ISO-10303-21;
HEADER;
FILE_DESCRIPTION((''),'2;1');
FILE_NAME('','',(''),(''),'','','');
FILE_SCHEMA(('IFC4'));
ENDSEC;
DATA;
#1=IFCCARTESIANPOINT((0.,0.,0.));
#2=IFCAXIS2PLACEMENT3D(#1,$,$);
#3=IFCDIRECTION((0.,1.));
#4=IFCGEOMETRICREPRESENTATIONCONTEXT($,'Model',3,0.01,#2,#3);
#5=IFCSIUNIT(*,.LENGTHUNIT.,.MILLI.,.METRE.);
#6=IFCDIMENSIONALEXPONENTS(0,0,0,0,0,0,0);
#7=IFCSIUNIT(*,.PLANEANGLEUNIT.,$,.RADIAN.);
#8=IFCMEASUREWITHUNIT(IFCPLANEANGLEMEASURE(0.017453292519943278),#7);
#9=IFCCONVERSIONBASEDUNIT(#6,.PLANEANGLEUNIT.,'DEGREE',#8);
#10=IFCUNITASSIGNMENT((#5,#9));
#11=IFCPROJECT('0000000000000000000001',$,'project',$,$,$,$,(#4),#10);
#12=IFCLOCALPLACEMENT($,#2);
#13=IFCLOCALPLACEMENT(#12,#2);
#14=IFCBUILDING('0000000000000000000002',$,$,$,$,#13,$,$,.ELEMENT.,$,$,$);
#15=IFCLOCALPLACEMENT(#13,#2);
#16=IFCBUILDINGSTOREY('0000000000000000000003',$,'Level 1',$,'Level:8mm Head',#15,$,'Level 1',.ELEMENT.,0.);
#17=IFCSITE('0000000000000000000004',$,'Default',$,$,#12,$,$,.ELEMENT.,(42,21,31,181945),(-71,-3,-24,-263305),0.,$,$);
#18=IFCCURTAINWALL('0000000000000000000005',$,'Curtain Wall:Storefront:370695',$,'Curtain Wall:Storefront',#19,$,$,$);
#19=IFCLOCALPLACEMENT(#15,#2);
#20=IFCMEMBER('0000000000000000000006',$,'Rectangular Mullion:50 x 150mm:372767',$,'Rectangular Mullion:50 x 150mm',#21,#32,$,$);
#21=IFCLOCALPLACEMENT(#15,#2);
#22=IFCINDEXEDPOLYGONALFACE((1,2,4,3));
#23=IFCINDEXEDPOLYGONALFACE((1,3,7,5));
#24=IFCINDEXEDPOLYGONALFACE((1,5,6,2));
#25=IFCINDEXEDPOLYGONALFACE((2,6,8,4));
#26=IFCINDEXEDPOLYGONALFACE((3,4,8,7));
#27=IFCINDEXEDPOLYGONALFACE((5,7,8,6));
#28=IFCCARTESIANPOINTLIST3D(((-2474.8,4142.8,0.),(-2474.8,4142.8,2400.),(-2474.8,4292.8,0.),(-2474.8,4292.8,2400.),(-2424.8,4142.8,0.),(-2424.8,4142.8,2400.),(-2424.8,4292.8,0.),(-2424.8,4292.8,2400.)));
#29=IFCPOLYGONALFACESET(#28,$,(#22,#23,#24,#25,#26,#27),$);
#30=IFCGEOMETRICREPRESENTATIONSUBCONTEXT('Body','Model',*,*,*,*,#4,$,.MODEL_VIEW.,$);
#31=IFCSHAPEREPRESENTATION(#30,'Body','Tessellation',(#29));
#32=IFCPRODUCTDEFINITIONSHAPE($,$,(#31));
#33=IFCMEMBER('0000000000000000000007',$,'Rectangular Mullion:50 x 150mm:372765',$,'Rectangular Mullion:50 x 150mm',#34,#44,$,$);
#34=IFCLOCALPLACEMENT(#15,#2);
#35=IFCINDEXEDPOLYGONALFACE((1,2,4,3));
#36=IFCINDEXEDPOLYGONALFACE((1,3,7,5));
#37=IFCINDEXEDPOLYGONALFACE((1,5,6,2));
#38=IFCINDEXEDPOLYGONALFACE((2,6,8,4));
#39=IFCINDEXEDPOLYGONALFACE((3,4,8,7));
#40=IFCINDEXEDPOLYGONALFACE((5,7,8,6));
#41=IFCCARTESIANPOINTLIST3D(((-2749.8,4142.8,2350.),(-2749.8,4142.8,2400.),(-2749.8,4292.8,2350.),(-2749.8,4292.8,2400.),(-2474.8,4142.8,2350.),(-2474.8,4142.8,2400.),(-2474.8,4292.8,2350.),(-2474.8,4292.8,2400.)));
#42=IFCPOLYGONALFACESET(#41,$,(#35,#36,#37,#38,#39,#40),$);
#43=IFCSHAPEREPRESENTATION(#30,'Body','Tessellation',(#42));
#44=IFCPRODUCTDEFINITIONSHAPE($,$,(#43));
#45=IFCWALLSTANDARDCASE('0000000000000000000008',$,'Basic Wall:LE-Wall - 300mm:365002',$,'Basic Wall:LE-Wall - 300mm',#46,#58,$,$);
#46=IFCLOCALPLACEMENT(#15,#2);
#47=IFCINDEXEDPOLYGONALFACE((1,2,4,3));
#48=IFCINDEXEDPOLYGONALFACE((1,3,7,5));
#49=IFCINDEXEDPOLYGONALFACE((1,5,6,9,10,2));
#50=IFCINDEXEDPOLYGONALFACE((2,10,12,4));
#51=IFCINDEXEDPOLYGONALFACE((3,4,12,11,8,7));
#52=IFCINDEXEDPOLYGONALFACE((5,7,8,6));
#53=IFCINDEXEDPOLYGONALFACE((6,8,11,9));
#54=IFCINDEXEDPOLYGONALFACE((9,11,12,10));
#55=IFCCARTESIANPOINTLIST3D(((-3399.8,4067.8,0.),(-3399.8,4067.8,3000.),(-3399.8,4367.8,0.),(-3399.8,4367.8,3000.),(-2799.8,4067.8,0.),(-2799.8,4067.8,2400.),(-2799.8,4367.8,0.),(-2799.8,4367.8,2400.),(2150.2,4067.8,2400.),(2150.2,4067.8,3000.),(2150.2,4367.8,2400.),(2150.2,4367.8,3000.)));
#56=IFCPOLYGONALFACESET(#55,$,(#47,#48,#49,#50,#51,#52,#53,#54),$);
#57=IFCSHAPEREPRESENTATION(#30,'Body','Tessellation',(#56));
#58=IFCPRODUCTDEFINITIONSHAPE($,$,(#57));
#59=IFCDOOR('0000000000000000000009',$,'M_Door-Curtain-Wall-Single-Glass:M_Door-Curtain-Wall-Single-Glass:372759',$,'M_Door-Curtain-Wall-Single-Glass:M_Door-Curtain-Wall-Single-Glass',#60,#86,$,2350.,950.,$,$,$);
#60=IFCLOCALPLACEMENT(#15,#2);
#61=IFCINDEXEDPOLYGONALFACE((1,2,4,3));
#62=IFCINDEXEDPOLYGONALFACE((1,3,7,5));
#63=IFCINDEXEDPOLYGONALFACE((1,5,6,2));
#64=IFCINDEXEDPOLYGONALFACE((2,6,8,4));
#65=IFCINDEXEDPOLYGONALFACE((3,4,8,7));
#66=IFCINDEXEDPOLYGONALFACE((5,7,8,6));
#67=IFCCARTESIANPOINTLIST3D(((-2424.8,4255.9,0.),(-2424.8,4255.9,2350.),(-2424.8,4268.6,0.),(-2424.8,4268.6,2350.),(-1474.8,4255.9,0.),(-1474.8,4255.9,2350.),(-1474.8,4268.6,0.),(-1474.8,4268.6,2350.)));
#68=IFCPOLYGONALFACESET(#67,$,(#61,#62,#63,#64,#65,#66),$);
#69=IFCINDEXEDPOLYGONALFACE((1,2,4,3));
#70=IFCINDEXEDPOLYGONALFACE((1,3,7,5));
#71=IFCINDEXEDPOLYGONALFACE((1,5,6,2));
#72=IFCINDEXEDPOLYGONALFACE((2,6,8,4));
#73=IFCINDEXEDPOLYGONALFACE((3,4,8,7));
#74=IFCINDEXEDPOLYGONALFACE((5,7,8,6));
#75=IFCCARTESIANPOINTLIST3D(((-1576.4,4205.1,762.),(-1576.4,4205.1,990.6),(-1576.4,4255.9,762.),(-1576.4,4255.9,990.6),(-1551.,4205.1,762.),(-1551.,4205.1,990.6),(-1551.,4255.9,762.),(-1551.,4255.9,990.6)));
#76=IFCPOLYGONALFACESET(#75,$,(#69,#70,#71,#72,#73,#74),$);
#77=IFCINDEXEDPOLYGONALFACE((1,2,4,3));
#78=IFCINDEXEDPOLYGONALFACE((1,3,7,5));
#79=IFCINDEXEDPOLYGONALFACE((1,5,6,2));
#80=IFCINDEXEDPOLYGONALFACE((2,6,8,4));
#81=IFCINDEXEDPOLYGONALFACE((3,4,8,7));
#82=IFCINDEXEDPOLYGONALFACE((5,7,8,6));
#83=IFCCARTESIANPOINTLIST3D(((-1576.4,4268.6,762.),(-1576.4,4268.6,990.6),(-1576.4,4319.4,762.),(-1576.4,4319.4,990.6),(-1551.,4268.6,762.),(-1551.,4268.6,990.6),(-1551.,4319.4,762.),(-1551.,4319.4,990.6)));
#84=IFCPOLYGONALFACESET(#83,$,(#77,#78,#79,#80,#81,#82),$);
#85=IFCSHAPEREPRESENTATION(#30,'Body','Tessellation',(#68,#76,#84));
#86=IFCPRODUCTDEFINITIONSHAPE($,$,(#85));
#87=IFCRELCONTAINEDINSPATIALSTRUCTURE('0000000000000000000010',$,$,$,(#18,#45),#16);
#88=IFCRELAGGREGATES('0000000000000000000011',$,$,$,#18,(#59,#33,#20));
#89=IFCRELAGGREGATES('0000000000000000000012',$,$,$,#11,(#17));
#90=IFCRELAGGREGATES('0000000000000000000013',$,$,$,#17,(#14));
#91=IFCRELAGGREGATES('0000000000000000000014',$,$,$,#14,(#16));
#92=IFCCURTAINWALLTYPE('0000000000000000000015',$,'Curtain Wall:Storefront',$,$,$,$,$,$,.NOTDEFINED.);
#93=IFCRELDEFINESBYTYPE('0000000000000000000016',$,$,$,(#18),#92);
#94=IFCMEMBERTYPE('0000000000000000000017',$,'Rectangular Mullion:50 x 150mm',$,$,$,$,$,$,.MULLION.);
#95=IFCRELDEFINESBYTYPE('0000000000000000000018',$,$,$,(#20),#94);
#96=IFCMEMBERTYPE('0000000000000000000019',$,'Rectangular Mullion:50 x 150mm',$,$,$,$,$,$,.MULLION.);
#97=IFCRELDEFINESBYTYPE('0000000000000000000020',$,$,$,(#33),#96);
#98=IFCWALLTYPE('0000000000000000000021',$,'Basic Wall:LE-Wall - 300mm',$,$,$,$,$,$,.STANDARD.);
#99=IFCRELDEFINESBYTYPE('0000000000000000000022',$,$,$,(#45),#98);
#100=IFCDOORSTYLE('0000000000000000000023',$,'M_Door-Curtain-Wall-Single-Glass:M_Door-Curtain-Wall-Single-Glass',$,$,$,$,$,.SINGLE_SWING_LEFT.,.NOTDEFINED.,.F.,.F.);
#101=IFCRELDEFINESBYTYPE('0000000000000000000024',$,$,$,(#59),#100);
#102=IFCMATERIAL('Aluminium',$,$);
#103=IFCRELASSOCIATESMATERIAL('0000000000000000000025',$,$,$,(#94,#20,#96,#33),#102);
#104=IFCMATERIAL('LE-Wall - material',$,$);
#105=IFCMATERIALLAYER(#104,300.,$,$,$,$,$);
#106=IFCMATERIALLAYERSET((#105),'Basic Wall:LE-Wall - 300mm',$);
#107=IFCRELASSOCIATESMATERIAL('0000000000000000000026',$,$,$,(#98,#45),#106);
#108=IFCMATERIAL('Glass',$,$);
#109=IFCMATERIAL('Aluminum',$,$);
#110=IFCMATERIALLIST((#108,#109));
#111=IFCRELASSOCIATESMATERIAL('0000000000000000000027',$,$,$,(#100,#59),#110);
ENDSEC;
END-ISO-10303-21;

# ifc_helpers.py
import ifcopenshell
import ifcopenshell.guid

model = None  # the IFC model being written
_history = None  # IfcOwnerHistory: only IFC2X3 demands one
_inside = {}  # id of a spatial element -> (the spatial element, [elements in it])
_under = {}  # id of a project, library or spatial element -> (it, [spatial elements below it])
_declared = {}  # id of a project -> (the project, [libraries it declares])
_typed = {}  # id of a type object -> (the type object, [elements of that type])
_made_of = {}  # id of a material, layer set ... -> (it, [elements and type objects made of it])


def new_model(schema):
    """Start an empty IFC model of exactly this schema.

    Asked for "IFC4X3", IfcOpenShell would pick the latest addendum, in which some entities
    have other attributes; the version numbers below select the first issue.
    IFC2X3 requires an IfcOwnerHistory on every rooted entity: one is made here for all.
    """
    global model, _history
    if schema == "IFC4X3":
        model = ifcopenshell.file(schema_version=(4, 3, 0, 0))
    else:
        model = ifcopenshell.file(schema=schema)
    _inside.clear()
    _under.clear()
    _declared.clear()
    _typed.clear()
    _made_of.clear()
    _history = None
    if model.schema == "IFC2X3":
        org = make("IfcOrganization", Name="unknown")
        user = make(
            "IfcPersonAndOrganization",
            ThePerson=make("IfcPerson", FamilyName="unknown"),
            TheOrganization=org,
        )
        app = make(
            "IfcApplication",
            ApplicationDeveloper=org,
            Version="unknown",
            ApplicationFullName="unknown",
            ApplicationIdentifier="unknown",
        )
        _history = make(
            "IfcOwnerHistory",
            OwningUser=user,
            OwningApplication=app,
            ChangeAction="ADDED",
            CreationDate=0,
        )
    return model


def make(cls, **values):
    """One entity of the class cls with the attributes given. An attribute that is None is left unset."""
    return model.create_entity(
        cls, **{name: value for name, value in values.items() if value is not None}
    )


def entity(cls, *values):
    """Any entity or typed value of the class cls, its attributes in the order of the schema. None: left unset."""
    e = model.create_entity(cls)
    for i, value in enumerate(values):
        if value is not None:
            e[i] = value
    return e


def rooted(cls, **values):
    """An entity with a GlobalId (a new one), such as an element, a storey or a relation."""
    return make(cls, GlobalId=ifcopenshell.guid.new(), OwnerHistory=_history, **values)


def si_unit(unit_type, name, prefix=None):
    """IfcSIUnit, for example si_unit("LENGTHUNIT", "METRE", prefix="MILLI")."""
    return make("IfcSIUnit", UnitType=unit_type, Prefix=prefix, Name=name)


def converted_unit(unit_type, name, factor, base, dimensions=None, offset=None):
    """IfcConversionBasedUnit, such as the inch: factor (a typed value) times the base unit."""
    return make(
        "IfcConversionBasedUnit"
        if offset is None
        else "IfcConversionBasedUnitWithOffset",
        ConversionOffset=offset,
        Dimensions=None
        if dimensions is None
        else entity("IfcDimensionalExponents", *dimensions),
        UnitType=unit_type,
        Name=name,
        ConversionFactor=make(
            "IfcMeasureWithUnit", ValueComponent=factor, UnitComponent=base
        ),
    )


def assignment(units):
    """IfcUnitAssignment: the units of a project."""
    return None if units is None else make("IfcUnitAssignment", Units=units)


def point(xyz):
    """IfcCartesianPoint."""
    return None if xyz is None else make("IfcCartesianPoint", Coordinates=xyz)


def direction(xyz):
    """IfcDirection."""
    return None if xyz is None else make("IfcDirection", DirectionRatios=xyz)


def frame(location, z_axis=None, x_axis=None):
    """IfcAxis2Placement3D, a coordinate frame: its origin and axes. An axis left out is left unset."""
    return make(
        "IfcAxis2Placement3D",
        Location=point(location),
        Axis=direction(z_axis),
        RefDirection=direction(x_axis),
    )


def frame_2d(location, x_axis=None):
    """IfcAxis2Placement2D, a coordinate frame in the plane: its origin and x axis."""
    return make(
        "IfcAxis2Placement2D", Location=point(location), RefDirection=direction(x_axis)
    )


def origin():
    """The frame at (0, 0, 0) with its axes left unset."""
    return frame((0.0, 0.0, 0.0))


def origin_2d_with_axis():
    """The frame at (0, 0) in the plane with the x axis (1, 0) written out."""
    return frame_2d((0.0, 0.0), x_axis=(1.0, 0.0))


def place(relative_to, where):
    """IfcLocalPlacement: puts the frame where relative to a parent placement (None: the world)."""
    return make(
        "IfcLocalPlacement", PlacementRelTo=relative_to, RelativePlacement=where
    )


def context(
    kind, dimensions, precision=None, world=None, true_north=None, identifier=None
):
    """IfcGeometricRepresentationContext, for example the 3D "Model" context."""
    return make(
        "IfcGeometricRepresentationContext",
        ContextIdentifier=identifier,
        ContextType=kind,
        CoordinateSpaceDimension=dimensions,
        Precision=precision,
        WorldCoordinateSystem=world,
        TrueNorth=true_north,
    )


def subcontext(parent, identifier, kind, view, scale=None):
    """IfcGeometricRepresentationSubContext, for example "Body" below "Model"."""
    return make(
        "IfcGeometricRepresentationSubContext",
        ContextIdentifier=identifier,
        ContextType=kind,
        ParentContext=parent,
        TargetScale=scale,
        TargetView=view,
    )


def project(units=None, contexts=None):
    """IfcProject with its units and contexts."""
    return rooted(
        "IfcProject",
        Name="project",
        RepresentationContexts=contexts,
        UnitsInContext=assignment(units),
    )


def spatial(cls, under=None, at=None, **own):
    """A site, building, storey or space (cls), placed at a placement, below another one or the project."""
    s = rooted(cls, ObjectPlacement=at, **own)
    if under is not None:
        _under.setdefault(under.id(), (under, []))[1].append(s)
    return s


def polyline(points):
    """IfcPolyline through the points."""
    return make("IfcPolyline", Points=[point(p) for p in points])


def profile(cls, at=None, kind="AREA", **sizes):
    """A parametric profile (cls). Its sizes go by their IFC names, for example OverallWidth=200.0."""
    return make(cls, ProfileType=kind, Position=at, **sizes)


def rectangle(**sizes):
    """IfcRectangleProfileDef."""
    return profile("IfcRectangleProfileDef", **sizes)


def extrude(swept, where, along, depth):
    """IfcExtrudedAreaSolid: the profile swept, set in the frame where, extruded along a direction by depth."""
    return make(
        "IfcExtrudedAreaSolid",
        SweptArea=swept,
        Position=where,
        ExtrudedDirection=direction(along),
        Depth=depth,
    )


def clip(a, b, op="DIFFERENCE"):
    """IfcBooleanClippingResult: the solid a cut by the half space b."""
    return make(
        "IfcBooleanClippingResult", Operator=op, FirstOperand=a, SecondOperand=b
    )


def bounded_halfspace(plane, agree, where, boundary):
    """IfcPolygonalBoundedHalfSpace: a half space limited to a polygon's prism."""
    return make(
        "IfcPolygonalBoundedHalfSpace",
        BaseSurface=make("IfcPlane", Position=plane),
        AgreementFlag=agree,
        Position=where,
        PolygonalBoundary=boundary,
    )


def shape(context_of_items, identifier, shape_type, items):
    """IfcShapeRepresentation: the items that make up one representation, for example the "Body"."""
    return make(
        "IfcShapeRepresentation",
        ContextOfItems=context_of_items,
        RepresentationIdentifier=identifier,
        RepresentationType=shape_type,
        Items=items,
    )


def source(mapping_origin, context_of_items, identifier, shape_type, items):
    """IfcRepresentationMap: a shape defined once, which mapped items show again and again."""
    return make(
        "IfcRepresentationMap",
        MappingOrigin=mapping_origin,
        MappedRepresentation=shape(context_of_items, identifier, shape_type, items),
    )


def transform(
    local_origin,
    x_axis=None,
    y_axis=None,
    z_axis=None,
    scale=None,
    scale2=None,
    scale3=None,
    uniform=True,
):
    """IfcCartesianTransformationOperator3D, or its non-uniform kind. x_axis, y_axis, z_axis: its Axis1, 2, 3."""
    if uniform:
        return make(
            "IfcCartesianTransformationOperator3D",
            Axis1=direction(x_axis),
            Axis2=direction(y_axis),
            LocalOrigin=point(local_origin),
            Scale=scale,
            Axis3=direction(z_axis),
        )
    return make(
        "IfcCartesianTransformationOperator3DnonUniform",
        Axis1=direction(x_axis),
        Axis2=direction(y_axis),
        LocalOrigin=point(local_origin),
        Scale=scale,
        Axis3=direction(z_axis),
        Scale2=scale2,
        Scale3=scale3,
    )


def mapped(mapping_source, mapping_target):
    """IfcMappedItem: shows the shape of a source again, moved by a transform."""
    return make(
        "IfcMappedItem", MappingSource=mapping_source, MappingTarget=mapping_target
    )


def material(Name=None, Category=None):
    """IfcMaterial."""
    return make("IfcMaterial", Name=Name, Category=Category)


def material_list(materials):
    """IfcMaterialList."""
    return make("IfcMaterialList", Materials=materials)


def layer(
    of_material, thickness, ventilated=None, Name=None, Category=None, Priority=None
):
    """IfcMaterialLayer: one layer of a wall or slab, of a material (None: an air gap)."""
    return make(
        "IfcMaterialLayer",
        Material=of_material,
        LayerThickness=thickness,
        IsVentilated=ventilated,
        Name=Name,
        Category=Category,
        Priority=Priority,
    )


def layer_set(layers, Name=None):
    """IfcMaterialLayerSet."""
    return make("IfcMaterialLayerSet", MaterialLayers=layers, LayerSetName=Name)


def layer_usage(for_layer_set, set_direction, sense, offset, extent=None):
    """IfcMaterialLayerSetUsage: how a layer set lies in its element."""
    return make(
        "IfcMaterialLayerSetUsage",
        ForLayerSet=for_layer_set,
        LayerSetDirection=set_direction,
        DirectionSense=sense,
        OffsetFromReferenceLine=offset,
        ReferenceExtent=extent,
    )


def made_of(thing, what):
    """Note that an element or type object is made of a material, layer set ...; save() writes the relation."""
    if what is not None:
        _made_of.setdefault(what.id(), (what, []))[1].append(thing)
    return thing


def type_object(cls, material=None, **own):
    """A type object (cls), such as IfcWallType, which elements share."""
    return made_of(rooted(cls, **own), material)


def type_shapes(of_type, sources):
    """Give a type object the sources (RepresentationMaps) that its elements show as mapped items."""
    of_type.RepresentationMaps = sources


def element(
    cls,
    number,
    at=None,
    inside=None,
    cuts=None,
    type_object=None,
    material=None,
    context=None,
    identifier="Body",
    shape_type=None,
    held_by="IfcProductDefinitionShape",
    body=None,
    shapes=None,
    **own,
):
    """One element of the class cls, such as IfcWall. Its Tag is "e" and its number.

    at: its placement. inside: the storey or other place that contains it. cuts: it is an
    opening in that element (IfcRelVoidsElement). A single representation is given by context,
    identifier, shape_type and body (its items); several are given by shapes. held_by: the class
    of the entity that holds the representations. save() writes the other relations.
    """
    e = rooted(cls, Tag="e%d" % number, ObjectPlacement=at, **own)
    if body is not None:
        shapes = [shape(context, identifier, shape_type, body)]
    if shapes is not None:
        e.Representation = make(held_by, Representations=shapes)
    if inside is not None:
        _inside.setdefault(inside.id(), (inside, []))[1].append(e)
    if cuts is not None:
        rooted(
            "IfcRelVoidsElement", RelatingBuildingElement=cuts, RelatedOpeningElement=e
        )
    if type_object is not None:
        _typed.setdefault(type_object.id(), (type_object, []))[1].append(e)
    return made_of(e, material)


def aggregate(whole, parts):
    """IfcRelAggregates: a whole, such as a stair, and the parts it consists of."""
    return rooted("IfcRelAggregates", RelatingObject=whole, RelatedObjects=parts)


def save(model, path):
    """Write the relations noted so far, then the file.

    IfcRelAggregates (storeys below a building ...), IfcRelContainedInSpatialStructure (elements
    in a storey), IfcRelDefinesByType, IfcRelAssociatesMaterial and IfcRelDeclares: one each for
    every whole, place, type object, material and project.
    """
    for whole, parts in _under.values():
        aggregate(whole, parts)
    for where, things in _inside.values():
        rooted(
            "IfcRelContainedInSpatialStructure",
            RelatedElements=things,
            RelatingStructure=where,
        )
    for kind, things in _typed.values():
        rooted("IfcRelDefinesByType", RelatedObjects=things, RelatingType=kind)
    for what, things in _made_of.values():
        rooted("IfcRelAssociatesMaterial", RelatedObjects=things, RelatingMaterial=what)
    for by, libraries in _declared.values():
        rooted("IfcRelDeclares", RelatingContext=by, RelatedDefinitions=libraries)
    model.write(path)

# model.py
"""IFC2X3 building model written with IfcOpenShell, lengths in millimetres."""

from ifc_helpers import new_model, entity, si_unit, converted_unit, direction, frame, frame_2d, origin, origin_2d_with_axis, place, context, subcontext, project, spatial, polyline, rectangle, extrude, clip, bounded_halfspace, source, transform, mapped, material, material_list, layer, layer_set, layer_usage, type_object, type_shapes, element, aggregate, save


model = new_model("IFC2X3")

# Units and contexts
model_context = context("Model", 3, precision=0.01, world=origin(), true_north=direction((0.0, 1.0)))
body_context = subcontext(model_context, "Body", "Model", "MODEL_VIEW")
ifc_project = project(units=[si_unit("LENGTHUNIT", "METRE", prefix="MILLI"), converted_unit("PLANEANGLEUNIT", "DEGREE", entity("IfcPlaneAngleMeasure", 0.017453292519943278), si_unit("PLANEANGLEUNIT", "RADIAN"), dimensions=[0, 0, 0, 0, 0, 0, 0])], contexts=[model_context])

# Site, building, storey
site_placement = place(None, origin())
site = spatial("IfcSite", under=ifc_project, at=site_placement, Name="Default", CompositionType="ELEMENT", RefLatitude=(42, 21, 31, 181945), RefLongitude=(-71, -3, -24, -263305), RefElevation=0.0)
building_placement = place(site_placement, origin())
building = spatial("IfcBuilding", under=site, at=building_placement, CompositionType="ELEMENT")
storey_placement = place(building_placement, origin())
storey = spatial("IfcBuildingStorey", under=building, at=storey_placement, Name="Level 1", ObjectType="Level:8mm Head", LongName="Level 1", CompositionType="ELEMENT", Elevation=0.0)

# Curtain wall, members
curtain_wall_type = type_object("IfcCurtainWallType", Name="Curtain Wall:Storefront", PredefinedType="NOTDEFINED")
curtain_wall_placement = place(storey_placement, origin())
curtain_wall = element("IfcCurtainWall", 1, at=curtain_wall_placement, inside=storey, type_object=curtain_wall_type, Name="Curtain Wall:Storefront:370695", ObjectType="Curtain Wall:Storefront")
ifc_material_1 = material(Name="Aluminium")
member_type_1 = type_object("IfcMemberType", Name="Rectangular Mullion:50 x 150mm", PredefinedType="MULLION", material=ifc_material_1)
shared_shape_1 = source(origin(), body_context, "Body", "SweptSolid", [
    extrude(rectangle(XDim=50.0, YDim=150.0, at=origin_2d_with_axis()), frame((0.0, 0.0, -2400.0), z_axis=(0.0, 0.0, 1.0), x_axis=(-1.0, 0.0, 0.0)), (0.0, 0.0, 1.0), 2400.0),
])
type_shapes(member_type_1, [shared_shape_1])
member_1_placement = place(curtain_wall_placement, frame((-2449.8, 4217.8, 0.0), z_axis=(0.0, 0.0, -1.0), x_axis=(1.0, 0.0, 0.0)))
member_1 = element("IfcMember", 2, at=member_1_placement, type_object=member_type_1, material=ifc_material_1, Name="Rectangular Mullion:50 x 150mm:372767", ObjectType="Rectangular Mullion:50 x 150mm", context=body_context, shape_type="MappedRepresentation", body=[
    mapped(shared_shape_1, transform((0.0, 0.0, 0.0), scale=1.0)),
])
member_type_2 = type_object("IfcMemberType", Name="Rectangular Mullion:50 x 150mm", PredefinedType="MULLION", material=ifc_material_1)
shared_shape_2 = source(origin(), body_context, "Body", "SweptSolid", [
    extrude(rectangle(XDim=50.0, YDim=150.0, at=origin_2d_with_axis()), frame((-25.0, 0.0, -275.0), z_axis=(0.0, 0.0, 1.0), x_axis=(-1.0, 0.0, 0.0)), (0.0, 0.0, 1.0), 275.0),
])
type_shapes(member_type_2, [shared_shape_2])
member_2_placement = place(curtain_wall_placement, frame((-2474.8, 4217.8, 2400.0), z_axis=(1.0, 0.0, 0.0), x_axis=(0.0, 0.0, 1.0)))
member_2 = element("IfcMember", 3, at=member_2_placement, type_object=member_type_2, material=ifc_material_1, Name="Rectangular Mullion:50 x 150mm:372765", ObjectType="Rectangular Mullion:50 x 150mm", context=body_context, shape_type="MappedRepresentation", body=[
    mapped(shared_shape_2, transform((0.0, 0.0, 0.0), scale=1.0)),
])
ifc_material_2 = material(Name="Glass")

# Wall, opening
ifc_material_3 = material(Name="LE-Wall - material")
ifc_layer = layer(ifc_material_3, 300.0)
ifc_layer_set = layer_set([ifc_layer], Name="Basic Wall:LE-Wall - 300mm")
ifc_layer_usage = layer_usage(ifc_layer_set, "AXIS2", "NEGATIVE", 150.0)
wall_type = type_object("IfcWallType", Name="Basic Wall:LE-Wall - 300mm", PredefinedType="STANDARD", material=ifc_layer_set)
wall_placement = place(storey_placement, frame((-3399.8, 4217.8, 0.0)))
wall = element("IfcWallStandardCase", 4, at=wall_placement, inside=storey, type_object=wall_type, material=ifc_layer_usage, Name="Basic Wall:LE-Wall - 300mm:365002", ObjectType="Basic Wall:LE-Wall - 300mm", context=body_context, shape_type="Clipping", body=[
    clip(extrude(rectangle(XDim=5550.0, YDim=300.0, at=frame_2d((2775.0, 0.0), x_axis=(-1.0, 0.0))), origin(), (0.0, 0.0, 1.0), 3000.0), bounded_halfspace(frame((0.0, 150.0, 3000.0), z_axis=(0.0, 0.0, -1.0), x_axis=(0.0, -1.0, 0.0)), True, frame((0.0, 150.0, 3000.0)), polyline([(0.0, 0.0), (0.0, -300.0), (300.0, -300.0), (5550.0, -300.0), (5550.0, 0.0), (0.0, 0.0)]))),
])
opening_placement = place(wall_placement, origin())
element("IfcOpeningElement", 5, at=opening_placement, cuts=wall, ObjectType="Opening", context=body_context, shape_type="SweptSolid", body=[
    extrude(rectangle(XDim=2400.0, YDim=5400.0, at=frame_2d((0.0, 0.0), x_axis=(1.0, 0.0))), frame((3300.0, -302.4, 1200.0), z_axis=(0.0, 1.0, 0.0), x_axis=(0.0, 0.0, 1.0)), (0.0, 0.0, 1.0), 604.8),
])

# Door
ifc_material_4 = material(Name="Aluminum")
ifc_material_list = material_list([ifc_material_2, ifc_material_4])
door_style = type_object("IfcDoorStyle", Name="M_Door-Curtain-Wall-Single-Glass:M_Door-Curtain-Wall-Single-Glass", ConstructionType="NOTDEFINED", OperationType="SINGLE_SWING_LEFT", ParameterTakesPrecedence=False, Sizeable=False, material=ifc_material_list)
shared_shape_3 = source(origin(), body_context, "Body", "SweptSolid", [
    extrude(rectangle(XDim=12.7, YDim=950.0, at=frame_2d((0.0, 0.0), x_axis=(1.0, 0.0))), frame((0.0, 44.5, 0.0), z_axis=(0.0, 0.0, 1.0), x_axis=(0.0, -1.0, 0.0)), (0.0, 0.0, 1.0), 2350.0),
    extrude(rectangle(XDim=25.4, YDim=50.8, at=frame_2d((0.0, 0.0), x_axis=(1.0, 0.0))), frame((386.1, 12.7, 762.0)), (0.0, 0.0, 1.0), 228.6),
    extrude(rectangle(XDim=25.4, YDim=50.8, at=frame_2d((0.0, 0.0), x_axis=(1.0, 0.0))), frame((386.1, 76.2, 762.0), z_axis=(0.0, 0.0, 1.0), x_axis=(-1.0, 0.0, 0.0)), (0.0, 0.0, 1.0), 228.6),
])
type_shapes(door_style, [shared_shape_3])
door_placement = place(curtain_wall_placement, frame((-1949.8, 4217.8, 0.0)))
door = element("IfcDoor", 6, at=door_placement, type_object=door_style, material=ifc_material_list, Name="M_Door-Curtain-Wall-Single-Glass:M_Door-Curtain-Wall-Single-Glass:372759", ObjectType="M_Door-Curtain-Wall-Single-Glass:M_Door-Curtain-Wall-Single-Glass", OverallHeight=2350.0, OverallWidth=950.0, context=body_context, shape_type="MappedRepresentation", body=[
    mapped(shared_shape_3, transform((0.0, 0.0, 0.0), scale=1.0)),
])
aggregate(curtain_wall, [door, member_2, member_1])

save(model, "model.ifc")
